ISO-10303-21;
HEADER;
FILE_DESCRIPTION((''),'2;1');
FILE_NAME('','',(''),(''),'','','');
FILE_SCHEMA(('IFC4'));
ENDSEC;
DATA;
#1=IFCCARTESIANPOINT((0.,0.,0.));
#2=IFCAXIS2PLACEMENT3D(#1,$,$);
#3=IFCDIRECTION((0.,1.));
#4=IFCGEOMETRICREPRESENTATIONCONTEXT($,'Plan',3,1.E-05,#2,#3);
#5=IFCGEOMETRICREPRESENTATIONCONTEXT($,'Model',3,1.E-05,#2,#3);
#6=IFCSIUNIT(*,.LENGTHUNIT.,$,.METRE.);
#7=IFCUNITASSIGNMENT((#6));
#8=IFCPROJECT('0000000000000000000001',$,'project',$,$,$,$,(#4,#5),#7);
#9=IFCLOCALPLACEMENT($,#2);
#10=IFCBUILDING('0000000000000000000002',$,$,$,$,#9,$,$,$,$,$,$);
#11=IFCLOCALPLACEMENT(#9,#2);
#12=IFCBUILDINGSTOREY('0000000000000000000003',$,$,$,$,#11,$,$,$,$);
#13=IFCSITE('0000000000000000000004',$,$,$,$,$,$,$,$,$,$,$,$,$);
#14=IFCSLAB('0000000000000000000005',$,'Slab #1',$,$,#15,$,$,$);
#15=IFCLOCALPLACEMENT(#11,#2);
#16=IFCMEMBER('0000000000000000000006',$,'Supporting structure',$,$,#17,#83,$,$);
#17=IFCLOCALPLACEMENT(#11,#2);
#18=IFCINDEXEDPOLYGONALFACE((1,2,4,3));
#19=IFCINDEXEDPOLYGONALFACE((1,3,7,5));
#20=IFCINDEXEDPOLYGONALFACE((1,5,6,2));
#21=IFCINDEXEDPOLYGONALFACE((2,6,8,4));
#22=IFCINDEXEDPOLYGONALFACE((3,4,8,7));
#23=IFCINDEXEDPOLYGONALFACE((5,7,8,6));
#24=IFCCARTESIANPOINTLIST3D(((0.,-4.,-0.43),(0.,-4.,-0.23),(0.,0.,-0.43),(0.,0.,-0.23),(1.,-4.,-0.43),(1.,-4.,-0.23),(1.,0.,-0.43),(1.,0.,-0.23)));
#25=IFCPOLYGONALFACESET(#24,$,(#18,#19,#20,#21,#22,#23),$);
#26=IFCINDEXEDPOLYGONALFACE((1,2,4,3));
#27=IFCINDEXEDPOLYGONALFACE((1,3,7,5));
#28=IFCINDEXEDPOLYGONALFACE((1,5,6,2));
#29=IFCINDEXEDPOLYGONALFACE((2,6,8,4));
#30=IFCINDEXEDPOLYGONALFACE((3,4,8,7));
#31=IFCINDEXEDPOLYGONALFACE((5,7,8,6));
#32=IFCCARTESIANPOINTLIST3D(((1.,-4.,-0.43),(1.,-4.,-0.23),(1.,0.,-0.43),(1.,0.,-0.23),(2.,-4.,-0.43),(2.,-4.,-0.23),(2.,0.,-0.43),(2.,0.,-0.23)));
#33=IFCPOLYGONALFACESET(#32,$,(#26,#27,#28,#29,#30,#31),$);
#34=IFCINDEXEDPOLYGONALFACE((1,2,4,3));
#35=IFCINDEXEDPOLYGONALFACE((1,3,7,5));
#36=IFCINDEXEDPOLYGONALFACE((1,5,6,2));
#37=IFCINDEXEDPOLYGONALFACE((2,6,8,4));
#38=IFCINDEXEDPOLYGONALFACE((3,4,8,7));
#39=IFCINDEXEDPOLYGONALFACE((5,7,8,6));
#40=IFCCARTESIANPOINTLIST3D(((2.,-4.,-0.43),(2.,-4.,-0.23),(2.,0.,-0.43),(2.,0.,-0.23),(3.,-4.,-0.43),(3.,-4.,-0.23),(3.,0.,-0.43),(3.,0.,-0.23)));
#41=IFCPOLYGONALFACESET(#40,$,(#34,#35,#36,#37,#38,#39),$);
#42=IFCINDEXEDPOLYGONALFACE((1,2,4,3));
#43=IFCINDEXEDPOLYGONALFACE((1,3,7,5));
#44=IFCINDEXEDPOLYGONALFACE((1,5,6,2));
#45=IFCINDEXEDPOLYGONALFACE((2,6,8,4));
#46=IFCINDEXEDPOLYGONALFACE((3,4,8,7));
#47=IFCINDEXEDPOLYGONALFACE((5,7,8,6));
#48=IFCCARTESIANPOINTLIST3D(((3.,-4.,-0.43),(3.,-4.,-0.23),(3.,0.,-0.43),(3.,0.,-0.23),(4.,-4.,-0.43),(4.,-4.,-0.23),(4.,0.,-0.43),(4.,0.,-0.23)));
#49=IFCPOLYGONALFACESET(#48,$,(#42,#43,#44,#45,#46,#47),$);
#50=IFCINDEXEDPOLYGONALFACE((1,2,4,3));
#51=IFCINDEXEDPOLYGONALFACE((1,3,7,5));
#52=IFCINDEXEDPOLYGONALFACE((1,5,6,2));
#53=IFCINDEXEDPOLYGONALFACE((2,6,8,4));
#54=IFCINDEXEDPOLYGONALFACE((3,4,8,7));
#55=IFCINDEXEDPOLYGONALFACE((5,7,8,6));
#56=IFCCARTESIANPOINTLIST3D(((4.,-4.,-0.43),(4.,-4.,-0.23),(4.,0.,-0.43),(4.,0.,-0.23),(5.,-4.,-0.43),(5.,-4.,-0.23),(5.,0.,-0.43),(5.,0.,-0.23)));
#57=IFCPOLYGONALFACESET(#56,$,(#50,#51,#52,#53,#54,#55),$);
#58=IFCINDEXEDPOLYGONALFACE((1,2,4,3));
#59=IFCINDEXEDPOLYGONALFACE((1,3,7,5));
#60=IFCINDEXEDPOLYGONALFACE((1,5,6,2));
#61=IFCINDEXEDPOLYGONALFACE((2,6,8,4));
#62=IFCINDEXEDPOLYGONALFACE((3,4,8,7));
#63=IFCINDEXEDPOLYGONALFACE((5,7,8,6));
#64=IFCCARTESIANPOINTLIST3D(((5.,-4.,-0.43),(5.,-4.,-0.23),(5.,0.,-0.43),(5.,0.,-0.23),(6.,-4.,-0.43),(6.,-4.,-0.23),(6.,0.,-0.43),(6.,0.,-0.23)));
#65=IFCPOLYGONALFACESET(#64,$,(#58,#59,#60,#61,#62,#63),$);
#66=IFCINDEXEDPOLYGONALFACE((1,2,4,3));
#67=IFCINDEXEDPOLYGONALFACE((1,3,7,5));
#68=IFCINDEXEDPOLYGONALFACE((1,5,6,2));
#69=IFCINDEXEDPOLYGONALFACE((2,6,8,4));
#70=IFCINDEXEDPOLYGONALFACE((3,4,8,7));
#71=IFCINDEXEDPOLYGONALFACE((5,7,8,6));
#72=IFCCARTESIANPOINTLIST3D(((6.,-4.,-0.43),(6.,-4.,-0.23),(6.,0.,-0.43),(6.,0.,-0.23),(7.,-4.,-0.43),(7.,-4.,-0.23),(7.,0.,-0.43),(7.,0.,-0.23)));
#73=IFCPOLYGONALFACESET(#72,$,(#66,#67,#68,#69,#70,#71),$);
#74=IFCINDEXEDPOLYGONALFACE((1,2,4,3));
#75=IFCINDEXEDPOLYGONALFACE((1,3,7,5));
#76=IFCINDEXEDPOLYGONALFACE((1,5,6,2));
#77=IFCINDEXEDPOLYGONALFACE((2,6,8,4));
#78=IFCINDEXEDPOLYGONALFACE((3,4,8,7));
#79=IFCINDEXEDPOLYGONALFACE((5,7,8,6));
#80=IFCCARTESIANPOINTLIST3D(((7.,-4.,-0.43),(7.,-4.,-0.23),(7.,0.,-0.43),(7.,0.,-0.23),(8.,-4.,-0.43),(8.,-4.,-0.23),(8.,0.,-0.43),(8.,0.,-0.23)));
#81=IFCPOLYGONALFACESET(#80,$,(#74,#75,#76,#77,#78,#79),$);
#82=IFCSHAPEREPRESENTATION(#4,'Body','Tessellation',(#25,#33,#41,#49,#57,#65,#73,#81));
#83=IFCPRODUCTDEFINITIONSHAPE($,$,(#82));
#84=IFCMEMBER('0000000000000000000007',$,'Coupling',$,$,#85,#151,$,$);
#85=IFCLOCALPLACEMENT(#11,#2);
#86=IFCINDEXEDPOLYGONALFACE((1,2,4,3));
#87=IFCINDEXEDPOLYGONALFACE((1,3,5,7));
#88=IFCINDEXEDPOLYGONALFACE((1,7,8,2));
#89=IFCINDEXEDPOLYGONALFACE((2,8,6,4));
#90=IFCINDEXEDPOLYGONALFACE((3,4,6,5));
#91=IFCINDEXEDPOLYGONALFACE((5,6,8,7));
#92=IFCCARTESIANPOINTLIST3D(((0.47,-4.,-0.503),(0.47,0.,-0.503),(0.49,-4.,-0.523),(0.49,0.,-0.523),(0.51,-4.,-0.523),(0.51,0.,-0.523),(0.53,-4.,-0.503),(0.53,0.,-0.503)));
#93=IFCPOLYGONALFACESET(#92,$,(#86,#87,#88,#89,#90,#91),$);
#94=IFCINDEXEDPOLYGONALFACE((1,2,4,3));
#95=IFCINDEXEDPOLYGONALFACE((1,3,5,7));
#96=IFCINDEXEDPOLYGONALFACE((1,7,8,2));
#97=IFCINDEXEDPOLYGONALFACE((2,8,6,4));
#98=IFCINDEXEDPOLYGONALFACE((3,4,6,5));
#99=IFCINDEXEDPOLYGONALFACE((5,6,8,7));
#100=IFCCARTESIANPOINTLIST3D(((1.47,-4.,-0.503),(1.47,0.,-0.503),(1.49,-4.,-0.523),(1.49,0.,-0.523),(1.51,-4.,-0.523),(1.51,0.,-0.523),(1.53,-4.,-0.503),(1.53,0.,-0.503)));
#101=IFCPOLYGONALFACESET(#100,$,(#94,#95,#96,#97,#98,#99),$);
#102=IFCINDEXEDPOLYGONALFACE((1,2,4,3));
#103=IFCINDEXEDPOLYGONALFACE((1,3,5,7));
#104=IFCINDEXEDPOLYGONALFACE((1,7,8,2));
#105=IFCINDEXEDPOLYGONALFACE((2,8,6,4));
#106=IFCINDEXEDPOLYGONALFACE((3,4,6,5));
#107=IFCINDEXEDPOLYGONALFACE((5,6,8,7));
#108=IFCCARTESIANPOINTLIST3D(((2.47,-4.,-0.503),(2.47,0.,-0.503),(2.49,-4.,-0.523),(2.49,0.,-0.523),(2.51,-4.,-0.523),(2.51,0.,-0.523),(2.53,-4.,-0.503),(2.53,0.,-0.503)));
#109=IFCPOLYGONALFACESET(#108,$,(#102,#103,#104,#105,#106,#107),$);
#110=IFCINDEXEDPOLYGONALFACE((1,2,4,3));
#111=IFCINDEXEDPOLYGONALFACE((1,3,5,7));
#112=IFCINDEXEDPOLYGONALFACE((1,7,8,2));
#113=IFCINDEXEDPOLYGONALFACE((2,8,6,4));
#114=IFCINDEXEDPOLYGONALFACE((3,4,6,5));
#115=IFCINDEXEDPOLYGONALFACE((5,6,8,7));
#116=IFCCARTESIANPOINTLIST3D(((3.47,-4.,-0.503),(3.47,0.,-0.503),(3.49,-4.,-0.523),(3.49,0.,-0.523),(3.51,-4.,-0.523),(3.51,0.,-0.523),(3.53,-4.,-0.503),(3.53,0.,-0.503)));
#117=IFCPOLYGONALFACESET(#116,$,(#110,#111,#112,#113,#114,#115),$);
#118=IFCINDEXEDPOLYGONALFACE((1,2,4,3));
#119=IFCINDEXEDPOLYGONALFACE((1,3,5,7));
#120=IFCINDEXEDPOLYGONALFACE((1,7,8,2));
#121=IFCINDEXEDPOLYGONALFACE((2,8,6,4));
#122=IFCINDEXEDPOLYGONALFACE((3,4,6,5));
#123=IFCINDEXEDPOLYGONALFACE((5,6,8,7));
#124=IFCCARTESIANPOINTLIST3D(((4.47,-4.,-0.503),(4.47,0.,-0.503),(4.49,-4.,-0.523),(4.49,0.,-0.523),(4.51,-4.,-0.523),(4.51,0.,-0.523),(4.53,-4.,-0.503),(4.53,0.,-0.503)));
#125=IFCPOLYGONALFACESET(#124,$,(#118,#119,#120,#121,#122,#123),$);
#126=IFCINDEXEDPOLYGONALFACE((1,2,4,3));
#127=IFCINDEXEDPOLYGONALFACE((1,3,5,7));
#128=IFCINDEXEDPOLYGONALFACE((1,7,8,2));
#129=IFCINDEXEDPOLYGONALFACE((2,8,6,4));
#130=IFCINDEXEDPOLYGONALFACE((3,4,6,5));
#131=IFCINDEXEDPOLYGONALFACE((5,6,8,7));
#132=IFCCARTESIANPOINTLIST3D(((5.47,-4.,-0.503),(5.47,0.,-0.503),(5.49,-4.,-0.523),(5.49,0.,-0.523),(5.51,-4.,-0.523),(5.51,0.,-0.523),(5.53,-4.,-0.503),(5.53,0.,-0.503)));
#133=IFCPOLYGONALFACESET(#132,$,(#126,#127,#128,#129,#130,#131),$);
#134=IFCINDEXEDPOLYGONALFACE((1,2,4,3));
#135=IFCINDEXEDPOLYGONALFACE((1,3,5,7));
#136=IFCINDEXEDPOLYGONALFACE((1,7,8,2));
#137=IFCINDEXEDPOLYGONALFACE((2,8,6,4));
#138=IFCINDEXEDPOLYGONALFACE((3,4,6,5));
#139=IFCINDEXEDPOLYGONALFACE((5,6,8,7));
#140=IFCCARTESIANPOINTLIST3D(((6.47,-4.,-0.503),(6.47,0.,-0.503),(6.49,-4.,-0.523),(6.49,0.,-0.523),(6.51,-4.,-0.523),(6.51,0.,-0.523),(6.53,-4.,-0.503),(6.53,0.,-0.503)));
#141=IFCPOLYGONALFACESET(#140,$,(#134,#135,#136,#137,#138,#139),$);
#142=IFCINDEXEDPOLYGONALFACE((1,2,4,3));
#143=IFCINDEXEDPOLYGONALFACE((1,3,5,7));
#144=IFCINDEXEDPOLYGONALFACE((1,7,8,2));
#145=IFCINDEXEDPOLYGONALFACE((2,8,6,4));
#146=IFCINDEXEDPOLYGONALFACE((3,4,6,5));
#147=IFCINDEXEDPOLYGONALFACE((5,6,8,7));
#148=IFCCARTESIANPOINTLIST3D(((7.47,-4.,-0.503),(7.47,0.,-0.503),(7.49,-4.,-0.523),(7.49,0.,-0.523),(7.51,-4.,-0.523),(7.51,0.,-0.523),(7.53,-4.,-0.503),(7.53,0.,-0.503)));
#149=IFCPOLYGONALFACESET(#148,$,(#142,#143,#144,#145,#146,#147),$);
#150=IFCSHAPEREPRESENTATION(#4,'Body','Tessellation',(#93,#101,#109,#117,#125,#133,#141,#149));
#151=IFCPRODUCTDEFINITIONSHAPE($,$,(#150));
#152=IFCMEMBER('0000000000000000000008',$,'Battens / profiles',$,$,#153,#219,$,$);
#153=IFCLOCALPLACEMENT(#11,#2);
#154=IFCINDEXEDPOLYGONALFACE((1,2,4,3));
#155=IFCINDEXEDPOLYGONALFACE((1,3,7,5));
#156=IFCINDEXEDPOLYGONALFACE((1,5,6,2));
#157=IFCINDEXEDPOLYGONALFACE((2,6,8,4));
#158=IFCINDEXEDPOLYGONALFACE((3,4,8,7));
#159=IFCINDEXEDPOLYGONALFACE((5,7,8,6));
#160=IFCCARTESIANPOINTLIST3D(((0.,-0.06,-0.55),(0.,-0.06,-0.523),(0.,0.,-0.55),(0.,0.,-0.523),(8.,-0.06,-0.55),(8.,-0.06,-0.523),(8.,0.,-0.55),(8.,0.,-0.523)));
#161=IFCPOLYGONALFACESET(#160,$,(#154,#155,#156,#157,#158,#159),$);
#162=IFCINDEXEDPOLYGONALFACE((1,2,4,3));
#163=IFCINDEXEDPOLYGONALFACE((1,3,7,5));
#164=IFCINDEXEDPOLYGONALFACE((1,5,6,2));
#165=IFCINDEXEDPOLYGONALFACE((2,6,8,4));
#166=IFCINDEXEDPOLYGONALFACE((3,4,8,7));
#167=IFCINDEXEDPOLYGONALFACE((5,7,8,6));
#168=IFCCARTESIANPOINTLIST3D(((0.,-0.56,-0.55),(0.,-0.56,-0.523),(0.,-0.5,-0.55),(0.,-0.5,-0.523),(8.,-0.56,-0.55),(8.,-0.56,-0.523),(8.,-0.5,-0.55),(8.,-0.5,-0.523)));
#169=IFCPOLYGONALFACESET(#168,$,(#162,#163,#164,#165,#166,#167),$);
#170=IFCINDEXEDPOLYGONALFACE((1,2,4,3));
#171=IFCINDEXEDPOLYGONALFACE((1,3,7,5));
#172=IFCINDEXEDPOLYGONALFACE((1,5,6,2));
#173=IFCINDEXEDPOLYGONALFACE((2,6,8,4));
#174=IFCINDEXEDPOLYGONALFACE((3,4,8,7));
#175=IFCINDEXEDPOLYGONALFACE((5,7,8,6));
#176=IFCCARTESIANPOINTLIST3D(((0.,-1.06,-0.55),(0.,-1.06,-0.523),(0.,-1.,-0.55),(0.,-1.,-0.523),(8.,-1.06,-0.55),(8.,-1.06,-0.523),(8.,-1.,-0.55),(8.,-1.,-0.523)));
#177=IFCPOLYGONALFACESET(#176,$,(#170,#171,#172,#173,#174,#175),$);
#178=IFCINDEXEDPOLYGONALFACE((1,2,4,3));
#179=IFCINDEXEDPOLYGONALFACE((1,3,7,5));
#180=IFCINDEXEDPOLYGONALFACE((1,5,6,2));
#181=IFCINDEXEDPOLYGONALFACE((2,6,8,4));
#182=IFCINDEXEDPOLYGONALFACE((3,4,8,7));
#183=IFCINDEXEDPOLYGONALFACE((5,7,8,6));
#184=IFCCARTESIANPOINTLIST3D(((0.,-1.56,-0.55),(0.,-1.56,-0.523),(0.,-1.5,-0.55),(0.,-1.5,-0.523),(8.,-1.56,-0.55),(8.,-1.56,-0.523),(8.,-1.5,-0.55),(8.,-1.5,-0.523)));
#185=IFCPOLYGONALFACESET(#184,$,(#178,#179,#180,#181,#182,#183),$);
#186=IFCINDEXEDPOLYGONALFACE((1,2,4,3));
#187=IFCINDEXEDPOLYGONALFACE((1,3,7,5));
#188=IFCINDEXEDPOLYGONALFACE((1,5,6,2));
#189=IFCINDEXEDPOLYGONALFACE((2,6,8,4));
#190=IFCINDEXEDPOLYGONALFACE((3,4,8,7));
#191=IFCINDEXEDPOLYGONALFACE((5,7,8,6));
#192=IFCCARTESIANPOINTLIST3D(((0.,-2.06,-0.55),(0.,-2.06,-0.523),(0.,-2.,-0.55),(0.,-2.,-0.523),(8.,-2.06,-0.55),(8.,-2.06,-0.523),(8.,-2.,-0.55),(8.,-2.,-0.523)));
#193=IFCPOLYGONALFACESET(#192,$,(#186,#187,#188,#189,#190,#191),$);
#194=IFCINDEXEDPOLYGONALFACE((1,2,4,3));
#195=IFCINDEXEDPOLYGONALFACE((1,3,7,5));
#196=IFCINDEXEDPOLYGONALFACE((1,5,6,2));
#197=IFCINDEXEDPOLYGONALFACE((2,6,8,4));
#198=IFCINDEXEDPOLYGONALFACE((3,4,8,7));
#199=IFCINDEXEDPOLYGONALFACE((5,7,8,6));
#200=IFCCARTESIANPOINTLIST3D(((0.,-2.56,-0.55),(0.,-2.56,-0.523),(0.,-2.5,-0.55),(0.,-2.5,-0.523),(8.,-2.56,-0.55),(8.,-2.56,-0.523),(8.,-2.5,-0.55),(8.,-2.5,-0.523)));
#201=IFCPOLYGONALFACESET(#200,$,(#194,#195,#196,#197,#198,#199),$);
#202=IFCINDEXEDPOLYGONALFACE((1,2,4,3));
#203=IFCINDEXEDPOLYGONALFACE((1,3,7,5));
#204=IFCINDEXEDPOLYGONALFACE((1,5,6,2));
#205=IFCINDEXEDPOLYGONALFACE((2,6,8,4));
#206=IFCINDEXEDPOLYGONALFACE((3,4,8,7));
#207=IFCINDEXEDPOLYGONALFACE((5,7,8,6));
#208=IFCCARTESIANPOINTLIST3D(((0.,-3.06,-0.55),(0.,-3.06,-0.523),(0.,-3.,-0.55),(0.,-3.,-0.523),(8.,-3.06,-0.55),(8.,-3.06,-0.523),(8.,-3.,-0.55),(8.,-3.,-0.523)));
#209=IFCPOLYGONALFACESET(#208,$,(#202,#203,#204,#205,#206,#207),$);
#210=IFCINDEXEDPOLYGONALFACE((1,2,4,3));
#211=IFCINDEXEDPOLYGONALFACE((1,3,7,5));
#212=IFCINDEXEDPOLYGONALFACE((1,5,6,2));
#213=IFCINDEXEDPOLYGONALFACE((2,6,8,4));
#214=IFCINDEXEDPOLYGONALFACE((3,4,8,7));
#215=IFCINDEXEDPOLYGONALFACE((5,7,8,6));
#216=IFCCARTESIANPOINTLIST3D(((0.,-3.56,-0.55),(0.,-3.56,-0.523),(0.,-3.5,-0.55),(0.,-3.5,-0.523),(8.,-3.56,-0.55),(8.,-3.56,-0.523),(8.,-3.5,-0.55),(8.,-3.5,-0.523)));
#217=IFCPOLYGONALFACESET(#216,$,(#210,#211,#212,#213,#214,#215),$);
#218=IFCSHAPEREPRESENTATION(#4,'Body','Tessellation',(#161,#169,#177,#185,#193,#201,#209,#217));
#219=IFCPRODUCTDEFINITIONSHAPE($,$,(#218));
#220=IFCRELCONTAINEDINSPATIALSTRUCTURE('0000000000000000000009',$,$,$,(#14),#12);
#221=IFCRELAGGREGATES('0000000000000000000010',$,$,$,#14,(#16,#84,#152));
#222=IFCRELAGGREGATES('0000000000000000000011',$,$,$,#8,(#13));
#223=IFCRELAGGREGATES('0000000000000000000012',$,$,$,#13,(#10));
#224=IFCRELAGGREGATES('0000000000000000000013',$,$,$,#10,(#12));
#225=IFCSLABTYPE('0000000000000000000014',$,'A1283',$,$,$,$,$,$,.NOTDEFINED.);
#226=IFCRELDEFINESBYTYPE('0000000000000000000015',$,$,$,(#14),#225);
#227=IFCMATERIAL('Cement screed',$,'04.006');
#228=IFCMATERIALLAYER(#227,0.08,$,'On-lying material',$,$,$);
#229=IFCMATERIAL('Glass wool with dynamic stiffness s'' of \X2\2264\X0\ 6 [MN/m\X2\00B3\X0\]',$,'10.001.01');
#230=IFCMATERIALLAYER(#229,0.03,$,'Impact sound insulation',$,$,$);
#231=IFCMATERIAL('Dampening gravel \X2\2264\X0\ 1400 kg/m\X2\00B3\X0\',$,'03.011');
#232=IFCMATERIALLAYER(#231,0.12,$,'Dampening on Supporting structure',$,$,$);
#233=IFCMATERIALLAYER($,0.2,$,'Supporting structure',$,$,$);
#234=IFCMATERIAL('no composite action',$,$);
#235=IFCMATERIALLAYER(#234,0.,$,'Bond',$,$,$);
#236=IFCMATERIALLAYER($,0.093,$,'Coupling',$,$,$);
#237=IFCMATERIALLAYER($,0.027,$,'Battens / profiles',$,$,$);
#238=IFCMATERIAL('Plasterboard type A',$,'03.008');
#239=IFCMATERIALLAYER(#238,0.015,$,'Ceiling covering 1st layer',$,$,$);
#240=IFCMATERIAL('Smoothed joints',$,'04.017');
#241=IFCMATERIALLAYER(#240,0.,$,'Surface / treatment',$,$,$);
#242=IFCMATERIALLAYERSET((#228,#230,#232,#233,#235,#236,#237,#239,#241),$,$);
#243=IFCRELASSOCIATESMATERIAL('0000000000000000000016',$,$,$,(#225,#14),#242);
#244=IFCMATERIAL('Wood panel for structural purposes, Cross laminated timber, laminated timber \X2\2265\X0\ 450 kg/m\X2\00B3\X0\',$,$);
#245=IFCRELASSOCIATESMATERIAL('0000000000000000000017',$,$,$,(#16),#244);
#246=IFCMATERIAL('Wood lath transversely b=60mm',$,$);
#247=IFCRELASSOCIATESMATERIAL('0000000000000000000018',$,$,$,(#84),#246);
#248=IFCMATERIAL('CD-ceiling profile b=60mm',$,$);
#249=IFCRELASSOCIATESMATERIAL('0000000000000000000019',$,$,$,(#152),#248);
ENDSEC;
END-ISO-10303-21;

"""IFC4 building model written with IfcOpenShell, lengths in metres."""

from ifc_helpers import new_model, si_unit, direction, frame, frame_2d, origin, place, context, project, spatial, polyline, rectangle, outline, extrude, material, layer, layer_set, type_object, element, aggregate, save


model = new_model("IFC4")

# Units and contexts
plan_context = context("Plan", 3, precision=1e-05, world=origin(), true_north=direction((0.0, 1.0)))
model_context = context("Model", 3, precision=1e-05, world=origin(), true_north=direction((0.0, 1.0)))
ifc_project = project(units=[si_unit("LENGTHUNIT", "METRE")], contexts=[plan_context, model_context])

# Site, building, storey
site = spatial("IfcSite", under=ifc_project)
building_placement = place(None, origin())
building = spatial("IfcBuilding", under=site, at=building_placement)
storey_placement = place(building_placement, origin())
storey = spatial("IfcBuildingStorey", under=building, at=storey_placement)

# Slab, members
ifc_material_1 = material(Name="Cement screed", Category="04.006")
ifc_layer_1 = layer(ifc_material_1, 0.08, Name="On-lying material")
ifc_material_2 = material(Name="Glass wool with dynamic stiffness s' of ≤ 6 [MN/m³]", Category="10.001.01")
ifc_layer_2 = layer(ifc_material_2, 0.03, Name="Impact sound insulation")
ifc_material_3 = material(Name="Dampening gravel ≤ 1400 kg/m³", Category="03.011")
ifc_layer_3 = layer(ifc_material_3, 0.12, Name="Dampening on Supporting structure")
ifc_layer_4 = layer(None, 0.2, Name="Supporting structure")
ifc_material_4 = material(Name="no composite action")
ifc_layer_5 = layer(ifc_material_4, 0.0, Name="Bond")
ifc_layer_6 = layer(None, 0.093, Name="Coupling")
ifc_layer_7 = layer(None, 0.027, Name="Battens / profiles")
ifc_material_5 = material(Name="Plasterboard type A", Category="03.008")
ifc_layer_8 = layer(ifc_material_5, 0.015, Name="Ceiling covering 1st layer")
ifc_material_6 = material(Name="Smoothed joints", Category="04.017")
ifc_layer_9 = layer(ifc_material_6, 0.0, Name="Surface / treatment")
ifc_layer_set = layer_set([ifc_layer_1, ifc_layer_2, ifc_layer_3, ifc_layer_4, ifc_layer_5, ifc_layer_6, ifc_layer_7, ifc_layer_8, ifc_layer_9])
slab_type = type_object("IfcSlabType", Name="A1283", PredefinedType="NOTDEFINED", material=ifc_layer_set)
slab_placement = place(None, frame((0.0, 0.0, 0.0), z_axis=(0.0, 0.0, -1.0), x_axis=(1.0, 0.0, 0.0)))
slab = element("IfcSlab", 1, at=slab_placement, inside=storey, type_object=slab_type, material=ifc_layer_set, Name="Slab #1")
ifc_material_7 = material(Name="Wood panel for structural purposes, Cross laminated timber, laminated timber ≥ 450 kg/m³")
member_1_placement = place(slab_placement, origin())
member_1 = element("IfcMember", 2, at=member_1_placement, material=ifc_material_7, Name="Supporting structure", context=plan_context, shape_type="SweptSolid", body=[
    extrude(rectangle(XDim=1.0, YDim=0.2, at=frame_2d((0.5, 0.1), x_axis=(1.0, 0.0))), frame((0.0, 4.0, 0.23), z_axis=(0.0, -1.0, 0.0), x_axis=(1.0, 0.0, 0.0)), (0.0, 0.0, 1.0), 4.0),
    extrude(rectangle(XDim=1.0, YDim=0.2, at=frame_2d((0.5, 0.1), x_axis=(1.0, 0.0))), frame((1.0, 4.0, 0.23), z_axis=(0.0, -1.0, 0.0), x_axis=(1.0, 0.0, 0.0)), (0.0, 0.0, 1.0), 4.0),
    extrude(rectangle(XDim=1.0, YDim=0.2, at=frame_2d((0.5, 0.1), x_axis=(1.0, 0.0))), frame((2.0, 4.0, 0.23), z_axis=(0.0, -1.0, 0.0), x_axis=(1.0, 0.0, 0.0)), (0.0, 0.0, 1.0), 4.0),
    extrude(rectangle(XDim=1.0, YDim=0.2, at=frame_2d((0.5, 0.1), x_axis=(1.0, 0.0))), frame((3.0, 4.0, 0.23), z_axis=(0.0, -1.0, 0.0), x_axis=(1.0, 0.0, 0.0)), (0.0, 0.0, 1.0), 4.0),
    extrude(rectangle(XDim=1.0, YDim=0.2, at=frame_2d((0.5, 0.1), x_axis=(1.0, 0.0))), frame((4.0, 4.0, 0.23), z_axis=(0.0, -1.0, 0.0), x_axis=(1.0, 0.0, 0.0)), (0.0, 0.0, 1.0), 4.0),
    extrude(rectangle(XDim=1.0, YDim=0.2, at=frame_2d((0.5, 0.1), x_axis=(1.0, 0.0))), frame((5.0, 4.0, 0.23), z_axis=(0.0, -1.0, 0.0), x_axis=(1.0, 0.0, 0.0)), (0.0, 0.0, 1.0), 4.0),
    extrude(rectangle(XDim=1.0, YDim=0.2, at=frame_2d((0.5, 0.1), x_axis=(1.0, 0.0))), frame((6.0, 4.0, 0.23), z_axis=(0.0, -1.0, 0.0), x_axis=(1.0, 0.0, 0.0)), (0.0, 0.0, 1.0), 4.0),
    extrude(rectangle(XDim=1.0, YDim=0.2, at=frame_2d((0.5, 0.1), x_axis=(1.0, 0.0))), frame((7.0, 4.0, 0.23), z_axis=(0.0, -1.0, 0.0), x_axis=(1.0, 0.0, 0.0)), (0.0, 0.0, 1.0), 4.0),
])
ifc_material_8 = material(Name="Wood lath transversely b=60mm")
member_2_placement = place(slab_placement, origin())
member_2 = element("IfcMember", 3, at=member_2_placement, material=ifc_material_8, Name="Coupling", context=plan_context, shape_type="SweptSolid", body=[
    extrude(outline(polyline([(0.0, 0.0), (0.06, 0.0), (0.04, 0.02), (0.02, 0.02), (0.0, 0.0)])), frame((0.47, 4.0, 0.503), z_axis=(0.0, -1.0, 0.0), x_axis=(1.0, 0.0, 0.0)), (0.0, 0.0, 1.0), 4.0),
    extrude(outline(polyline([(0.0, 0.0), (0.06, 0.0), (0.04, 0.02), (0.02, 0.02), (0.0, 0.0)])), frame((1.47, 4.0, 0.503), z_axis=(0.0, -1.0, 0.0), x_axis=(1.0, 0.0, 0.0)), (0.0, 0.0, 1.0), 4.0),
    extrude(outline(polyline([(0.0, 0.0), (0.06, 0.0), (0.04, 0.02), (0.02, 0.02), (0.0, 0.0)])), frame((2.47, 4.0, 0.503), z_axis=(0.0, -1.0, 0.0), x_axis=(1.0, 0.0, 0.0)), (0.0, 0.0, 1.0), 4.0),
    extrude(outline(polyline([(0.0, 0.0), (0.06, 0.0), (0.04, 0.02), (0.02, 0.02), (0.0, 0.0)])), frame((3.47, 4.0, 0.503), z_axis=(0.0, -1.0, 0.0), x_axis=(1.0, 0.0, 0.0)), (0.0, 0.0, 1.0), 4.0),
    extrude(outline(polyline([(0.0, 0.0), (0.06, 0.0), (0.04, 0.02), (0.02, 0.02), (0.0, 0.0)])), frame((4.47, 4.0, 0.503), z_axis=(0.0, -1.0, 0.0), x_axis=(1.0, 0.0, 0.0)), (0.0, 0.0, 1.0), 4.0),
    extrude(outline(polyline([(0.0, 0.0), (0.06, 0.0), (0.04, 0.02), (0.02, 0.02), (0.0, 0.0)])), frame((5.47, 4.0, 0.503), z_axis=(0.0, -1.0, 0.0), x_axis=(1.0, 0.0, 0.0)), (0.0, 0.0, 1.0), 4.0),
    extrude(outline(polyline([(0.0, 0.0), (0.06, 0.0), (0.04, 0.02), (0.02, 0.02), (0.0, 0.0)])), frame((6.47, 4.0, 0.503), z_axis=(0.0, -1.0, 0.0), x_axis=(1.0, 0.0, 0.0)), (0.0, 0.0, 1.0), 4.0),
    extrude(outline(polyline([(0.0, 0.0), (0.06, 0.0), (0.04, 0.02), (0.02, 0.02), (0.0, 0.0)])), frame((7.47, 4.0, 0.503), z_axis=(0.0, -1.0, 0.0), x_axis=(1.0, 0.0, 0.0)), (0.0, 0.0, 1.0), 4.0),
])
ifc_material_9 = material(Name="CD-ceiling profile b=60mm")
member_3_placement = place(slab_placement, origin())
member_3 = element("IfcMember", 4, at=member_3_placement, material=ifc_material_9, Name="Battens / profiles", context=plan_context, shape_type="SweptSolid", body=[
    extrude(rectangle(XDim=0.06, YDim=0.027, at=frame_2d((0.03, 0.0135), x_axis=(1.0, 0.0))), frame((0.0, 0.0, 0.523), z_axis=(1.0, 0.0, 0.0), x_axis=(0.0, 1.0, 0.0)), (0.0, 0.0, 1.0), 8.0),
    extrude(rectangle(XDim=0.06, YDim=0.027, at=frame_2d((0.03, 0.0135), x_axis=(1.0, 0.0))), frame((0.0, 0.5, 0.523), z_axis=(1.0, 0.0, 0.0), x_axis=(0.0, 1.0, 0.0)), (0.0, 0.0, 1.0), 8.0),
    extrude(rectangle(XDim=0.06, YDim=0.027, at=frame_2d((0.03, 0.0135), x_axis=(1.0, 0.0))), frame((0.0, 1.0, 0.523), z_axis=(1.0, 0.0, 0.0), x_axis=(0.0, 1.0, 0.0)), (0.0, 0.0, 1.0), 8.0),
    extrude(rectangle(XDim=0.06, YDim=0.027, at=frame_2d((0.03, 0.0135), x_axis=(1.0, 0.0))), frame((0.0, 1.5, 0.523), z_axis=(1.0, 0.0, 0.0), x_axis=(0.0, 1.0, 0.0)), (0.0, 0.0, 1.0), 8.0),
    extrude(rectangle(XDim=0.06, YDim=0.027, at=frame_2d((0.03, 0.0135), x_axis=(1.0, 0.0))), frame((0.0, 2.0, 0.523), z_axis=(1.0, 0.0, 0.0), x_axis=(0.0, 1.0, 0.0)), (0.0, 0.0, 1.0), 8.0),
    extrude(rectangle(XDim=0.06, YDim=0.027, at=frame_2d((0.03, 0.0135), x_axis=(1.0, 0.0))), frame((0.0, 2.5, 0.523), z_axis=(1.0, 0.0, 0.0), x_axis=(0.0, 1.0, 0.0)), (0.0, 0.0, 1.0), 8.0),
    extrude(rectangle(XDim=0.06, YDim=0.027, at=frame_2d((0.03, 0.0135), x_axis=(1.0, 0.0))), frame((0.0, 3.0, 0.523), z_axis=(1.0, 0.0, 0.0), x_axis=(0.0, 1.0, 0.0)), (0.0, 0.0, 1.0), 8.0),
    extrude(rectangle(XDim=0.06, YDim=0.027, at=frame_2d((0.03, 0.0135), x_axis=(1.0, 0.0))), frame((0.0, 3.5, 0.523), z_axis=(1.0, 0.0, 0.0), x_axis=(0.0, 1.0, 0.0)), (0.0, 0.0, 1.0), 8.0),
])
aggregate(slab, [member_1, member_2, member_3])

save(model, "model.ifc")
